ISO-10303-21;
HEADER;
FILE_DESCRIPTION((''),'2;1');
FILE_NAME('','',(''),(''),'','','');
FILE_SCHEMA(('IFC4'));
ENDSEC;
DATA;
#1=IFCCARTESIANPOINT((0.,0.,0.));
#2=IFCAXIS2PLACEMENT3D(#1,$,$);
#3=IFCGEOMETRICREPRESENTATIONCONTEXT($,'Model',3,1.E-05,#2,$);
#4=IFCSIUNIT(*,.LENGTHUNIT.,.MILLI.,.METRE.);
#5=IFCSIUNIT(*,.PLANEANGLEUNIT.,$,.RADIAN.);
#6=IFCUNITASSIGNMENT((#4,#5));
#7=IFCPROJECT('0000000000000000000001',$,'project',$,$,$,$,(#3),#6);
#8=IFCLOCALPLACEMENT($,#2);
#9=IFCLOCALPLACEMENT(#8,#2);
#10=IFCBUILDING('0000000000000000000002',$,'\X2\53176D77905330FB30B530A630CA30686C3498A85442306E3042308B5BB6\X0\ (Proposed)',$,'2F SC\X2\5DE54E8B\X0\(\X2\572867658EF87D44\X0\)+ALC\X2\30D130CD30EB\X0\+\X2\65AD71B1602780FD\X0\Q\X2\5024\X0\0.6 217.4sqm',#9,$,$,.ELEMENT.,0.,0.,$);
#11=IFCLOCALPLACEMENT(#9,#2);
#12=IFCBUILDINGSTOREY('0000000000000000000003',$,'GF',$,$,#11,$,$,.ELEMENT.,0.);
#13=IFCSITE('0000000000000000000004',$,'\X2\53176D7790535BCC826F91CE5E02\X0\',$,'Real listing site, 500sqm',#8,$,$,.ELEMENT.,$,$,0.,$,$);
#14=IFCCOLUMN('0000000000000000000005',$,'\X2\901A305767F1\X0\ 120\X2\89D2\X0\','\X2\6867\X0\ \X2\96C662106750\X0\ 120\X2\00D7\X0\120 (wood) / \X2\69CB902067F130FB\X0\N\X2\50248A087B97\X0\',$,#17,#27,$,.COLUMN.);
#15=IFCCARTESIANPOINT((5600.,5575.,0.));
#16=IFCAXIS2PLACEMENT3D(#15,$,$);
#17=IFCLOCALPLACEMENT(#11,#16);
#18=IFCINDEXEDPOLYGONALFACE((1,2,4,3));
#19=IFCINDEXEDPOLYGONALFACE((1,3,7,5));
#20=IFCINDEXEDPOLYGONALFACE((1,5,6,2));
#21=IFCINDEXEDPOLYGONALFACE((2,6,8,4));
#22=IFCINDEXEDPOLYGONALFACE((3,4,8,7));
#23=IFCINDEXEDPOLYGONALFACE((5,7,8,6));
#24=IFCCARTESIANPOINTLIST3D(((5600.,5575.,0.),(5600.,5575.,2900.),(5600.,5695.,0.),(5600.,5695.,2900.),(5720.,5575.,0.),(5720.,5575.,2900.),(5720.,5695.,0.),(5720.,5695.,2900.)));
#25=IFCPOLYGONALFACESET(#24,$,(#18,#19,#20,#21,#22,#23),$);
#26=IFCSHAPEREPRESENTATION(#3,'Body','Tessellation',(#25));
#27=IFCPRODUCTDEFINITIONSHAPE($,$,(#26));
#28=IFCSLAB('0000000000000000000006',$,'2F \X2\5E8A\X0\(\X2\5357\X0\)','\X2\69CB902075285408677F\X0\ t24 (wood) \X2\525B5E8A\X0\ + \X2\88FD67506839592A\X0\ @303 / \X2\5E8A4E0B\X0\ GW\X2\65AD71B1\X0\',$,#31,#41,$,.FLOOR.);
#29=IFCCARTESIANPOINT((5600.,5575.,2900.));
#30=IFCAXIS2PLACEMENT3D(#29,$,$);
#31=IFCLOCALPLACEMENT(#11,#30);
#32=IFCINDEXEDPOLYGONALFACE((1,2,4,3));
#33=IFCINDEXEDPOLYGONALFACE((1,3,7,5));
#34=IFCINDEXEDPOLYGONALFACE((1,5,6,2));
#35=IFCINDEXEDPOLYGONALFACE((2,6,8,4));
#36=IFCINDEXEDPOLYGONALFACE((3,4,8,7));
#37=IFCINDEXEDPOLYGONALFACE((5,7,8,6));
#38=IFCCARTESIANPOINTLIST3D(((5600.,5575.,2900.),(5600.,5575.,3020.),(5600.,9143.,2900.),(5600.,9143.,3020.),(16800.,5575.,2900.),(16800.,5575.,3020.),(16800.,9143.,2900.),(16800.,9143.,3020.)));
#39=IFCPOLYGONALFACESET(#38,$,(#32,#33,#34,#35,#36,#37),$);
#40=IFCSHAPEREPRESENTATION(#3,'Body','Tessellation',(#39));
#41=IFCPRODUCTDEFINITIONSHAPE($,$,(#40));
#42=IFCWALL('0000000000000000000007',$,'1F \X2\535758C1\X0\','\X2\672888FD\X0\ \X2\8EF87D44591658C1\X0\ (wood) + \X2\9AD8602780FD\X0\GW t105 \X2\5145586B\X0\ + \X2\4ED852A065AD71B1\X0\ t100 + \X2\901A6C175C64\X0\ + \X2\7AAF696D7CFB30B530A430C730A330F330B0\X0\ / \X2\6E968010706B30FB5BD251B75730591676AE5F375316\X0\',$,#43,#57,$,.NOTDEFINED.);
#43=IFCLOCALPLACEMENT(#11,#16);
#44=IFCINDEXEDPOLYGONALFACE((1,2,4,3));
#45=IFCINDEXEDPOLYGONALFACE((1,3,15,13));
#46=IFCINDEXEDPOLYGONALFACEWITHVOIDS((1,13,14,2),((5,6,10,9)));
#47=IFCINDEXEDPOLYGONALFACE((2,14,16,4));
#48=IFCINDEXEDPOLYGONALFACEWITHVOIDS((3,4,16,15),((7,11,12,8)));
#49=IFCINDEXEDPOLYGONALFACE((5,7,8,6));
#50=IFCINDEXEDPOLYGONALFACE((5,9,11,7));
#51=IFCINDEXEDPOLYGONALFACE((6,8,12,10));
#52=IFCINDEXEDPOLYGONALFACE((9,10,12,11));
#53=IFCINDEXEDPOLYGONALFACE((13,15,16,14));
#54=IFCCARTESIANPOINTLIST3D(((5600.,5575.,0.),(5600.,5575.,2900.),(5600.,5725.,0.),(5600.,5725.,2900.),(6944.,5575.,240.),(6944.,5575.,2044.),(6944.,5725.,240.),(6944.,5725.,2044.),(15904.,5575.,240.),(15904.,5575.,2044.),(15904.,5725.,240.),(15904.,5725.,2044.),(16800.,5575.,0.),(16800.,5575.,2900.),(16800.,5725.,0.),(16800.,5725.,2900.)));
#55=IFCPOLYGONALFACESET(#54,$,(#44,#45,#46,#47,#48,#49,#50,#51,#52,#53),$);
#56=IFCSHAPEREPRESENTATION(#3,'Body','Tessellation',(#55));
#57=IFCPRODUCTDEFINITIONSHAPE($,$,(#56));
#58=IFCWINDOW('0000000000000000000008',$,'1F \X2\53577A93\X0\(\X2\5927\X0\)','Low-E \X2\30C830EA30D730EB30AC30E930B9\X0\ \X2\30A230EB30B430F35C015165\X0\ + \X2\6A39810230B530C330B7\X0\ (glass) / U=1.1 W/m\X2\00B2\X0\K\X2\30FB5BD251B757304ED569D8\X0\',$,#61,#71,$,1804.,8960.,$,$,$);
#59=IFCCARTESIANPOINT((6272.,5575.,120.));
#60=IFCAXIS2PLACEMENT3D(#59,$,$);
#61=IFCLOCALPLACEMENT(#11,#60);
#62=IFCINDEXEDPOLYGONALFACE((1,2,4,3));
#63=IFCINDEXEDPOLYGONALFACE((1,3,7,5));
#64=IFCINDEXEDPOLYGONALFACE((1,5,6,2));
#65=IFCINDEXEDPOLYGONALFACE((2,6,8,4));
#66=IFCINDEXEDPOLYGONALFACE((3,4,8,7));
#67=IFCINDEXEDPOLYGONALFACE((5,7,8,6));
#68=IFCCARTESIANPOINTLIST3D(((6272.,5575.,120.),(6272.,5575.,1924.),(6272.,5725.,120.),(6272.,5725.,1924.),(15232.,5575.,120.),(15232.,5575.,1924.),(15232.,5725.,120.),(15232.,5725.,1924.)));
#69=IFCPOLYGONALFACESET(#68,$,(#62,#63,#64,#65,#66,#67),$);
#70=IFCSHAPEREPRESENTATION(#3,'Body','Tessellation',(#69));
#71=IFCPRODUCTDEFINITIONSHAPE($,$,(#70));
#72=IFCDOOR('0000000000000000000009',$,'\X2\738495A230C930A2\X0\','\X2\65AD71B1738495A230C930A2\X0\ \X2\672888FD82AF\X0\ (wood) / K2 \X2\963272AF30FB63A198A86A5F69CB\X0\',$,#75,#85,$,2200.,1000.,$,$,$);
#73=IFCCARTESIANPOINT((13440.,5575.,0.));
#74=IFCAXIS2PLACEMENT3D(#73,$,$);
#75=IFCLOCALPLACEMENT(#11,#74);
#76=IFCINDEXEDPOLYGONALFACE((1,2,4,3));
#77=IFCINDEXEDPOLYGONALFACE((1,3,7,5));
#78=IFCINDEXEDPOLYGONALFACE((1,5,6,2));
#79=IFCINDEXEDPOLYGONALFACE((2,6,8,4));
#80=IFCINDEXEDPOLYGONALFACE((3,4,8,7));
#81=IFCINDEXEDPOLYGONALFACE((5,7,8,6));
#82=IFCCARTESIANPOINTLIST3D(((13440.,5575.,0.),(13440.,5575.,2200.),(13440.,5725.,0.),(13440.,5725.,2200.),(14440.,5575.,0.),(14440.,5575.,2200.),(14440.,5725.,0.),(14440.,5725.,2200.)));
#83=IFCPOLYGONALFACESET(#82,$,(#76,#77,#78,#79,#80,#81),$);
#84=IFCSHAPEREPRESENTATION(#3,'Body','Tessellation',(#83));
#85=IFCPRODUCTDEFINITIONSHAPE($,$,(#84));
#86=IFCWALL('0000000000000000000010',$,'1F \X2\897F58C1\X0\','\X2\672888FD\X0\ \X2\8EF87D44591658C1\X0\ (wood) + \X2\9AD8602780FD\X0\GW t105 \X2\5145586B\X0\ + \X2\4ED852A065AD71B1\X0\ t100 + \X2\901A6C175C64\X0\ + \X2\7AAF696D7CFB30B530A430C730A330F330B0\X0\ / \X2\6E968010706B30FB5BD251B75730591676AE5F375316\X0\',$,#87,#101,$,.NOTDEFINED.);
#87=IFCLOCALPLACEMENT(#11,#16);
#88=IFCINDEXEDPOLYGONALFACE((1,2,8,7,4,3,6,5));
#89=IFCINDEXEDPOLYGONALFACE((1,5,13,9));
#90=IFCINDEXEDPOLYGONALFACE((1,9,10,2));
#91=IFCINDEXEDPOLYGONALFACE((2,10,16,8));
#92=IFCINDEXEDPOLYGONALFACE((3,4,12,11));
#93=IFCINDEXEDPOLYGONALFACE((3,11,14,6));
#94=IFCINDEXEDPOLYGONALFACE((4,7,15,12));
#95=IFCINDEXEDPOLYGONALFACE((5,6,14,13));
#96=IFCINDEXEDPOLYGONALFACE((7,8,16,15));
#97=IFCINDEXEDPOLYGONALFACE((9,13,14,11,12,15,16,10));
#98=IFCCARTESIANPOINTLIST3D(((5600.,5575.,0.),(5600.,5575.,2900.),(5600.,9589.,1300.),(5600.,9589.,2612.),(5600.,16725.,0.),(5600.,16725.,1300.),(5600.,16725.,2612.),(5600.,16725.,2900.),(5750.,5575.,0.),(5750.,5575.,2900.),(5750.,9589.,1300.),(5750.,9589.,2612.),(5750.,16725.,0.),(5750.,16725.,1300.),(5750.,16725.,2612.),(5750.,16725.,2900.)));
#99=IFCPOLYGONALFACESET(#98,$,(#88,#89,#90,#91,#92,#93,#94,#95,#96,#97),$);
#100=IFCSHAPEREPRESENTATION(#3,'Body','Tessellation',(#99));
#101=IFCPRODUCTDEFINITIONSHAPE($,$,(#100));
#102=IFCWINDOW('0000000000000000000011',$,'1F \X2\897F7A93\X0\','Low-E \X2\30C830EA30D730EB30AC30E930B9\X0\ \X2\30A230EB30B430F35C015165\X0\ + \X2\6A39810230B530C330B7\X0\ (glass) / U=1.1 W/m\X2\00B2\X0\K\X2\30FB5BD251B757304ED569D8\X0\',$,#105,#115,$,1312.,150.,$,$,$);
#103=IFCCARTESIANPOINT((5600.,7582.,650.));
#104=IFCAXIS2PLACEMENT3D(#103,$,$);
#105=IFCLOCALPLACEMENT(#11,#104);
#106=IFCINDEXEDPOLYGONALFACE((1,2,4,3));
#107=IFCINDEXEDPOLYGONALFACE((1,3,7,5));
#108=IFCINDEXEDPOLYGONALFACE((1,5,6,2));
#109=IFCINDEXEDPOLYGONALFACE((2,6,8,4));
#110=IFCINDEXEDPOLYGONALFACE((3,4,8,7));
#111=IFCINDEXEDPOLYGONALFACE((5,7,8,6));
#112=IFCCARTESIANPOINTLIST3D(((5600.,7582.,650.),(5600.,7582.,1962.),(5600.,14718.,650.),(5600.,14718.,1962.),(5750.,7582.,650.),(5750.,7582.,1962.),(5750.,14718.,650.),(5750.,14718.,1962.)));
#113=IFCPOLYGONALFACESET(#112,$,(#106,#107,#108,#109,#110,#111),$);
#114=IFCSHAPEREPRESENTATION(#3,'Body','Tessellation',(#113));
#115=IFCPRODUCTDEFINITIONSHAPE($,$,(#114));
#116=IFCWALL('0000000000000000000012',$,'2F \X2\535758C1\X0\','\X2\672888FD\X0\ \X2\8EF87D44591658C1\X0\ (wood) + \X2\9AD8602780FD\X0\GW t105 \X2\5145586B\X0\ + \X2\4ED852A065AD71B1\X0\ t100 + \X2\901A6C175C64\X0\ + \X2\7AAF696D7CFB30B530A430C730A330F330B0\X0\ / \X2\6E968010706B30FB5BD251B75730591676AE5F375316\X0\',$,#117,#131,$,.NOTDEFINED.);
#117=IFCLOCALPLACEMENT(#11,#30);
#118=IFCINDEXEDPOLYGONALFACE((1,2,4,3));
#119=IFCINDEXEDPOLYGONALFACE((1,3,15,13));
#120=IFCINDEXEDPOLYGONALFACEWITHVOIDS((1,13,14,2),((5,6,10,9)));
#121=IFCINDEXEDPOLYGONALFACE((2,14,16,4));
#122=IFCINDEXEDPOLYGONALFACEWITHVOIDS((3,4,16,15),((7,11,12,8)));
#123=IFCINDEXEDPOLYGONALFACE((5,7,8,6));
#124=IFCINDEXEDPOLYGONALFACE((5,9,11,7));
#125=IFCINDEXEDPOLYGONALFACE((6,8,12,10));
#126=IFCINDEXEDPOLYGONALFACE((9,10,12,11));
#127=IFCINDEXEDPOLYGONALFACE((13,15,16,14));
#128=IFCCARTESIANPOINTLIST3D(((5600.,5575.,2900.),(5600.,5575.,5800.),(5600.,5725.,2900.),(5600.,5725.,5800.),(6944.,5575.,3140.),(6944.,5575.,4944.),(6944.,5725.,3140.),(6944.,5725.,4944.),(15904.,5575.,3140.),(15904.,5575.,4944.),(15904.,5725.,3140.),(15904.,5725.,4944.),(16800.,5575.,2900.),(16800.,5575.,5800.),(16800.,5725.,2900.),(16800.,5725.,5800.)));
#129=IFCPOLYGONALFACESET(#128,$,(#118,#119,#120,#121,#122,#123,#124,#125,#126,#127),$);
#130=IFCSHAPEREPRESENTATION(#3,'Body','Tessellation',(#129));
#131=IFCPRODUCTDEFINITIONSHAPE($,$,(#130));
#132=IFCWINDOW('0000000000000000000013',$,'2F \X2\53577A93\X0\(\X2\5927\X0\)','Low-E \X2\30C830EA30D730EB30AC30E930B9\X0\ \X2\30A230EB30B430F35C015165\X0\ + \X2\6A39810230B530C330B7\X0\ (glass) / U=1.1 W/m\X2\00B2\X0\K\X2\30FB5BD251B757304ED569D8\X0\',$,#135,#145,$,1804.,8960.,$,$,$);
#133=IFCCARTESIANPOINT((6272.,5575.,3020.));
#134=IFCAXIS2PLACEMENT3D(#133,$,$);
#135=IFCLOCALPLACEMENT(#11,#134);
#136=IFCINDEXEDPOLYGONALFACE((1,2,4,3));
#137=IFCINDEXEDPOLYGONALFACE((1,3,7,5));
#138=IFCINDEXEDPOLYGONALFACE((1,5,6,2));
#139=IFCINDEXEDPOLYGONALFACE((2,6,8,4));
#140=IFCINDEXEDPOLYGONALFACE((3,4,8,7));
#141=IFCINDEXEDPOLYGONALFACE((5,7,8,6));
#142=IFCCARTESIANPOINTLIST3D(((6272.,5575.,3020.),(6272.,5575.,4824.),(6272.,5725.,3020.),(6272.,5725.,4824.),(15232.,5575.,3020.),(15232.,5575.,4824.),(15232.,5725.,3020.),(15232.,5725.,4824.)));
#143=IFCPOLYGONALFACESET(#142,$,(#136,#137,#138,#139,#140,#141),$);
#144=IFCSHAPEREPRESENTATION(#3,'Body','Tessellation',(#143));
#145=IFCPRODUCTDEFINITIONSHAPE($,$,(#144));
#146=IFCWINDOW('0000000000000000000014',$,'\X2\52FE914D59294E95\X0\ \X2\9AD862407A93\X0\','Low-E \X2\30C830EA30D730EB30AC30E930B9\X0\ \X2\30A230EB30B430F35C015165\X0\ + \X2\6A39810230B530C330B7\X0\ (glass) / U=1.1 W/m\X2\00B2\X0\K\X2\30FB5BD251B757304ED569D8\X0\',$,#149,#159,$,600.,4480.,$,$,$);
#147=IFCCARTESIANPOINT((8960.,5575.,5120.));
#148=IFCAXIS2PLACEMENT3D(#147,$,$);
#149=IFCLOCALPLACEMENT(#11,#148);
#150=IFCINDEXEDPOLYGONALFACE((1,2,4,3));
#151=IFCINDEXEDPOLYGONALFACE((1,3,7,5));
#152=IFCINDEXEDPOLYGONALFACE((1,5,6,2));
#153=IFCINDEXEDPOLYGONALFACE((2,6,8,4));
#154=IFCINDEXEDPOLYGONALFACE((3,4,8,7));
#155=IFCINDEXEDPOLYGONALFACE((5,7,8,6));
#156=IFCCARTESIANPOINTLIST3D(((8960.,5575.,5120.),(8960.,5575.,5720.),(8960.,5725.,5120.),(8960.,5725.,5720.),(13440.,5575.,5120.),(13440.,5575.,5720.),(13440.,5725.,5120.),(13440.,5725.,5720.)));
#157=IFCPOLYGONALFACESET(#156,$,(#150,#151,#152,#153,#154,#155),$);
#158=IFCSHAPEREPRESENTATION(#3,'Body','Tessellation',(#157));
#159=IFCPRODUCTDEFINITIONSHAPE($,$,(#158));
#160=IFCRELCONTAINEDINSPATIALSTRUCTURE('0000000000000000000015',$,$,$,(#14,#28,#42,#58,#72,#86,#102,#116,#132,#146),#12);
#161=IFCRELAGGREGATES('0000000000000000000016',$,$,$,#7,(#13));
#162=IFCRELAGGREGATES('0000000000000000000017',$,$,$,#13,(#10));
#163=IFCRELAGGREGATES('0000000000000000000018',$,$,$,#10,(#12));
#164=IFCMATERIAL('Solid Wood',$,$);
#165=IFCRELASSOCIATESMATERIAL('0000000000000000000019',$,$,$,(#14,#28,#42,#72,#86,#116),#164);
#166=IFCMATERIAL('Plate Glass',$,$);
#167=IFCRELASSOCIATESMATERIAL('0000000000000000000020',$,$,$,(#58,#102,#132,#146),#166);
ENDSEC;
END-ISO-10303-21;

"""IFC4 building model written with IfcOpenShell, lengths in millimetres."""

from ifc_helpers import new_model, si_unit, frame, frame_2d, origin, place, context, project, spatial, rectangle, extrude, material, element, fill, save


model = new_model("IFC4")

# Units and contexts
model_context = context("Model", 3, precision=1e-05, world=origin())
ifc_project = project(units=[si_unit("LENGTHUNIT", "METRE", prefix="MILLI"), si_unit("PLANEANGLEUNIT", "RADIAN")], contexts=[model_context])

# Site, building, storey
site_placement = place(None, origin())
site = spatial("IfcSite", under=ifc_project, at=site_placement, Name="北海道富良野市", ObjectType="Real listing site, 500sqm", CompositionType="ELEMENT", RefElevation=0.0)
building_placement = place(site_placement, origin())
building = spatial("IfcBuilding", under=site, at=building_placement, Name="北海道・サウナと水風呂のある家 (Proposed)", ObjectType="2F SC工事(在来軸組)+ALCパネル+断熱性能Q値0.6 217.4sqm", CompositionType="ELEMENT", ElevationOfRefHeight=0.0, ElevationOfTerrain=0.0)
storey_placement = place(building_placement, origin())
storey = spatial("IfcBuildingStorey", under=building, at=storey_placement, Name="GF", CompositionType="ELEMENT", Elevation=0.0)

# Column
ifc_material_1 = material(Name="Solid Wood")
column_placement = place(storey_placement, frame((5600.0, 5575.0, 0.0)))
element("IfcColumn", 1, at=column_placement, inside=storey, material=ifc_material_1, Name="通し柱 120角", Description="桧 集成材 120×120 (wood) / 構造柱・N値計算", PredefinedType="COLUMN", context=model_context, shape_type="SweptSolid", body=[
    extrude(rectangle(XDim=120.0, YDim=120.0, at=frame_2d((60.0, 60.0))), frame((5600.0, 5575.0, 0.0)), (0.0, 0.0, 1.0), 2900.0),
])

# Slab
slab_1_placement = place(storey_placement, frame((5600.0, 5575.0, 2900.0)))
element("IfcSlab", 2, at=slab_1_placement, inside=storey, material=ifc_material_1, Name="2F 床(南)", Description="構造用合板 t24 (wood) 剛床 + 製材根太 @303 / 床下 GW断熱", PredefinedType="FLOOR", context=model_context, shape_type="SweptSolid", body=[
    extrude(rectangle(XDim=11200.0, YDim=3568.0, at=frame_2d((5600.0, 1784.0))), frame((5600.0, 5575.0, 2900.0)), (0.0, 0.0, 1.0), 120.0),
])

# Wall, openings, window, door
wall_1_placement = place(storey_placement, frame((5600.0, 5575.0, 0.0)))
wall_1 = element("IfcWall", 3, at=wall_1_placement, inside=storey, material=ifc_material_1, Name="1F 南壁", Description="木製 軸組外壁 (wood) + 高性能GW t105 充填 + 付加断熱 t100 + 通気層 + 窯業系サイディング / 準耐火・寒冷地外皮強化", PredefinedType="NOTDEFINED", context=model_context, shape_type="SweptSolid", body=[
    extrude(rectangle(XDim=11200.0, YDim=150.0, at=frame_2d((5600.0, 75.0))), frame((5600.0, 5575.0, 0.0)), (0.0, 0.0, 1.0), 2900.0),
])
opening_1_placement = place(storey_placement, frame((6272.0, 5575.0, 120.0)))
opening_1 = element("IfcOpeningElement", 4, at=opening_1_placement, cuts=wall_1, PredefinedType="NOTDEFINED", context=model_context, shape_type="SweptSolid", body=[
    extrude(rectangle(XDim=8960.0, YDim=150.0, at=frame_2d((4480.0, 75.0))), frame((6272.0, 5575.0, 120.0)), (0.0, 0.0, 1.0), 1804.0),
])
opening_2_placement = place(storey_placement, frame((13440.0, 5575.0, 0.0)))
opening_2 = element("IfcOpeningElement", 5, at=opening_2_placement, cuts=wall_1, PredefinedType="NOTDEFINED", context=model_context, shape_type="SweptSolid", body=[
    extrude(rectangle(XDim=1000.0, YDim=150.0, at=frame_2d((500.0, 75.0))), frame((13440.0, 5575.0, 0.0)), (0.0, 0.0, 1.0), 2200.0),
])
ifc_material_2 = material(Name="Plate Glass")
window_1_placement = place(storey_placement, frame((6272.0, 5575.0, 120.0)))
window_1 = element("IfcWindow", 6, at=window_1_placement, inside=storey, material=ifc_material_2, Name="1F 南窓(大)", Description="Low-E トリプルガラス アルゴン封入 + 樹脂サッシ (glass) / U=1.1 W/m²K・寒冷地仕様", OverallHeight=1804.0, OverallWidth=8960.0, context=model_context, shape_type="SweptSolid", body=[
    extrude(rectangle(XDim=8960.0, YDim=150.0, at=frame_2d((4480.0, 75.0))), frame((6272.0, 5575.0, 120.0)), (0.0, 0.0, 1.0), 1804.0),
])
fill(opening_1, window_1)
door_placement = place(storey_placement, frame((13440.0, 5575.0, 0.0)))
door = element("IfcDoor", 7, at=door_placement, inside=storey, material=ifc_material_1, Name="玄関ドア", Description="断熱玄関ドア 木製芯 (wood) / K2 防犯・採風機構", OverallHeight=2200.0, OverallWidth=1000.0, context=model_context, shape_type="SweptSolid", body=[
    extrude(rectangle(XDim=1000.0, YDim=150.0, at=frame_2d((500.0, 75.0))), frame((13440.0, 5575.0, 0.0)), (0.0, 0.0, 1.0), 2200.0),
])
fill(opening_2, door)

# Wall, opening, window
wall_2_placement = place(storey_placement, frame((5600.0, 5575.0, 0.0)))
wall_2 = element("IfcWall", 8, at=wall_2_placement, inside=storey, material=ifc_material_1, Name="1F 西壁", Description="木製 軸組外壁 (wood) + 高性能GW t105 充填 + 付加断熱 t100 + 通気層 + 窯業系サイディング / 準耐火・寒冷地外皮強化", PredefinedType="NOTDEFINED", context=model_context, shape_type="SweptSolid", body=[
    extrude(rectangle(XDim=150.0, YDim=11150.0, at=frame_2d((75.0, 5575.0))), frame((5600.0, 5575.0, 0.0)), (0.0, 0.0, 1.0), 2900.0),
])
opening_3_placement = place(storey_placement, frame((5600.0, 7582.0, 650.0)))
opening_3 = element("IfcOpeningElement", 9, at=opening_3_placement, cuts=wall_2, PredefinedType="NOTDEFINED", context=model_context, shape_type="SweptSolid", body=[
    extrude(rectangle(XDim=150.0, YDim=7136.0, at=frame_2d((75.0, 3568.0))), frame((5600.0, 7582.0, 650.0)), (0.0, 0.0, 1.0), 1312.0),
])
window_2_placement = place(storey_placement, frame((5600.0, 7582.0, 650.0)))
window_2 = element("IfcWindow", 10, at=window_2_placement, inside=storey, material=ifc_material_2, Name="1F 西窓", Description="Low-E トリプルガラス アルゴン封入 + 樹脂サッシ (glass) / U=1.1 W/m²K・寒冷地仕様", OverallHeight=1312.0, OverallWidth=150.0, context=model_context, shape_type="SweptSolid", body=[
    extrude(rectangle(XDim=150.0, YDim=7136.0, at=frame_2d((75.0, 3568.0))), frame((5600.0, 7582.0, 650.0)), (0.0, 0.0, 1.0), 1312.0),
])
fill(opening_3, window_2)

# Wall, openings, windows
wall_3_placement = place(storey_placement, frame((5600.0, 5575.0, 2900.0)))
wall_3 = element("IfcWall", 11, at=wall_3_placement, inside=storey, material=ifc_material_1, Name="2F 南壁", Description="木製 軸組外壁 (wood) + 高性能GW t105 充填 + 付加断熱 t100 + 通気層 + 窯業系サイディング / 準耐火・寒冷地外皮強化", PredefinedType="NOTDEFINED", context=model_context, shape_type="SweptSolid", body=[
    extrude(rectangle(XDim=11200.0, YDim=150.0, at=frame_2d((5600.0, 75.0))), frame((5600.0, 5575.0, 2900.0)), (0.0, 0.0, 1.0), 2900.0),
])
opening_4_placement = place(storey_placement, frame((6272.0, 5575.0, 3020.0)))
opening_4 = element("IfcOpeningElement", 12, at=opening_4_placement, cuts=wall_3, PredefinedType="NOTDEFINED", context=model_context, shape_type="SweptSolid", body=[
    extrude(rectangle(XDim=8960.0, YDim=150.0, at=frame_2d((4480.0, 75.0))), frame((6272.0, 5575.0, 3020.0)), (0.0, 0.0, 1.0), 1804.0),
])
opening_5_placement = place(storey_placement, frame((8960.0, 5575.0, 5120.0)))
opening_5 = element("IfcOpeningElement", 13, at=opening_5_placement, cuts=wall_3, PredefinedType="NOTDEFINED", context=model_context, shape_type="SweptSolid", body=[
    extrude(rectangle(XDim=4480.0, YDim=150.0, at=frame_2d((2240.0, 75.0))), frame((8960.0, 5575.0, 5120.0)), (0.0, 0.0, 1.0), 600.0),
])
window_3_placement = place(storey_placement, frame((6272.0, 5575.0, 3020.0)))
window_3 = element("IfcWindow", 14, at=window_3_placement, inside=storey, material=ifc_material_2, Name="2F 南窓(大)", Description="Low-E トリプルガラス アルゴン封入 + 樹脂サッシ (glass) / U=1.1 W/m²K・寒冷地仕様", OverallHeight=1804.0, OverallWidth=8960.0, context=model_context, shape_type="SweptSolid", body=[
    extrude(rectangle(XDim=8960.0, YDim=150.0, at=frame_2d((4480.0, 75.0))), frame((6272.0, 5575.0, 3020.0)), (0.0, 0.0, 1.0), 1804.0),
])
fill(opening_4, window_3)
window_4_placement = place(storey_placement, frame((8960.0, 5575.0, 5120.0)))
window_4 = element("IfcWindow", 15, at=window_4_placement, inside=storey, material=ifc_material_2, Name="勾配天井 高所窓", Description="Low-E トリプルガラス アルゴン封入 + 樹脂サッシ (glass) / U=1.1 W/m²K・寒冷地仕様", OverallHeight=600.0, OverallWidth=4480.0, context=model_context, shape_type="SweptSolid", body=[
    extrude(rectangle(XDim=4480.0, YDim=150.0, at=frame_2d((2240.0, 75.0))), frame((8960.0, 5575.0, 5120.0)), (0.0, 0.0, 1.0), 600.0),
])
fill(opening_5, window_4)

save(model, "model.ifc")
